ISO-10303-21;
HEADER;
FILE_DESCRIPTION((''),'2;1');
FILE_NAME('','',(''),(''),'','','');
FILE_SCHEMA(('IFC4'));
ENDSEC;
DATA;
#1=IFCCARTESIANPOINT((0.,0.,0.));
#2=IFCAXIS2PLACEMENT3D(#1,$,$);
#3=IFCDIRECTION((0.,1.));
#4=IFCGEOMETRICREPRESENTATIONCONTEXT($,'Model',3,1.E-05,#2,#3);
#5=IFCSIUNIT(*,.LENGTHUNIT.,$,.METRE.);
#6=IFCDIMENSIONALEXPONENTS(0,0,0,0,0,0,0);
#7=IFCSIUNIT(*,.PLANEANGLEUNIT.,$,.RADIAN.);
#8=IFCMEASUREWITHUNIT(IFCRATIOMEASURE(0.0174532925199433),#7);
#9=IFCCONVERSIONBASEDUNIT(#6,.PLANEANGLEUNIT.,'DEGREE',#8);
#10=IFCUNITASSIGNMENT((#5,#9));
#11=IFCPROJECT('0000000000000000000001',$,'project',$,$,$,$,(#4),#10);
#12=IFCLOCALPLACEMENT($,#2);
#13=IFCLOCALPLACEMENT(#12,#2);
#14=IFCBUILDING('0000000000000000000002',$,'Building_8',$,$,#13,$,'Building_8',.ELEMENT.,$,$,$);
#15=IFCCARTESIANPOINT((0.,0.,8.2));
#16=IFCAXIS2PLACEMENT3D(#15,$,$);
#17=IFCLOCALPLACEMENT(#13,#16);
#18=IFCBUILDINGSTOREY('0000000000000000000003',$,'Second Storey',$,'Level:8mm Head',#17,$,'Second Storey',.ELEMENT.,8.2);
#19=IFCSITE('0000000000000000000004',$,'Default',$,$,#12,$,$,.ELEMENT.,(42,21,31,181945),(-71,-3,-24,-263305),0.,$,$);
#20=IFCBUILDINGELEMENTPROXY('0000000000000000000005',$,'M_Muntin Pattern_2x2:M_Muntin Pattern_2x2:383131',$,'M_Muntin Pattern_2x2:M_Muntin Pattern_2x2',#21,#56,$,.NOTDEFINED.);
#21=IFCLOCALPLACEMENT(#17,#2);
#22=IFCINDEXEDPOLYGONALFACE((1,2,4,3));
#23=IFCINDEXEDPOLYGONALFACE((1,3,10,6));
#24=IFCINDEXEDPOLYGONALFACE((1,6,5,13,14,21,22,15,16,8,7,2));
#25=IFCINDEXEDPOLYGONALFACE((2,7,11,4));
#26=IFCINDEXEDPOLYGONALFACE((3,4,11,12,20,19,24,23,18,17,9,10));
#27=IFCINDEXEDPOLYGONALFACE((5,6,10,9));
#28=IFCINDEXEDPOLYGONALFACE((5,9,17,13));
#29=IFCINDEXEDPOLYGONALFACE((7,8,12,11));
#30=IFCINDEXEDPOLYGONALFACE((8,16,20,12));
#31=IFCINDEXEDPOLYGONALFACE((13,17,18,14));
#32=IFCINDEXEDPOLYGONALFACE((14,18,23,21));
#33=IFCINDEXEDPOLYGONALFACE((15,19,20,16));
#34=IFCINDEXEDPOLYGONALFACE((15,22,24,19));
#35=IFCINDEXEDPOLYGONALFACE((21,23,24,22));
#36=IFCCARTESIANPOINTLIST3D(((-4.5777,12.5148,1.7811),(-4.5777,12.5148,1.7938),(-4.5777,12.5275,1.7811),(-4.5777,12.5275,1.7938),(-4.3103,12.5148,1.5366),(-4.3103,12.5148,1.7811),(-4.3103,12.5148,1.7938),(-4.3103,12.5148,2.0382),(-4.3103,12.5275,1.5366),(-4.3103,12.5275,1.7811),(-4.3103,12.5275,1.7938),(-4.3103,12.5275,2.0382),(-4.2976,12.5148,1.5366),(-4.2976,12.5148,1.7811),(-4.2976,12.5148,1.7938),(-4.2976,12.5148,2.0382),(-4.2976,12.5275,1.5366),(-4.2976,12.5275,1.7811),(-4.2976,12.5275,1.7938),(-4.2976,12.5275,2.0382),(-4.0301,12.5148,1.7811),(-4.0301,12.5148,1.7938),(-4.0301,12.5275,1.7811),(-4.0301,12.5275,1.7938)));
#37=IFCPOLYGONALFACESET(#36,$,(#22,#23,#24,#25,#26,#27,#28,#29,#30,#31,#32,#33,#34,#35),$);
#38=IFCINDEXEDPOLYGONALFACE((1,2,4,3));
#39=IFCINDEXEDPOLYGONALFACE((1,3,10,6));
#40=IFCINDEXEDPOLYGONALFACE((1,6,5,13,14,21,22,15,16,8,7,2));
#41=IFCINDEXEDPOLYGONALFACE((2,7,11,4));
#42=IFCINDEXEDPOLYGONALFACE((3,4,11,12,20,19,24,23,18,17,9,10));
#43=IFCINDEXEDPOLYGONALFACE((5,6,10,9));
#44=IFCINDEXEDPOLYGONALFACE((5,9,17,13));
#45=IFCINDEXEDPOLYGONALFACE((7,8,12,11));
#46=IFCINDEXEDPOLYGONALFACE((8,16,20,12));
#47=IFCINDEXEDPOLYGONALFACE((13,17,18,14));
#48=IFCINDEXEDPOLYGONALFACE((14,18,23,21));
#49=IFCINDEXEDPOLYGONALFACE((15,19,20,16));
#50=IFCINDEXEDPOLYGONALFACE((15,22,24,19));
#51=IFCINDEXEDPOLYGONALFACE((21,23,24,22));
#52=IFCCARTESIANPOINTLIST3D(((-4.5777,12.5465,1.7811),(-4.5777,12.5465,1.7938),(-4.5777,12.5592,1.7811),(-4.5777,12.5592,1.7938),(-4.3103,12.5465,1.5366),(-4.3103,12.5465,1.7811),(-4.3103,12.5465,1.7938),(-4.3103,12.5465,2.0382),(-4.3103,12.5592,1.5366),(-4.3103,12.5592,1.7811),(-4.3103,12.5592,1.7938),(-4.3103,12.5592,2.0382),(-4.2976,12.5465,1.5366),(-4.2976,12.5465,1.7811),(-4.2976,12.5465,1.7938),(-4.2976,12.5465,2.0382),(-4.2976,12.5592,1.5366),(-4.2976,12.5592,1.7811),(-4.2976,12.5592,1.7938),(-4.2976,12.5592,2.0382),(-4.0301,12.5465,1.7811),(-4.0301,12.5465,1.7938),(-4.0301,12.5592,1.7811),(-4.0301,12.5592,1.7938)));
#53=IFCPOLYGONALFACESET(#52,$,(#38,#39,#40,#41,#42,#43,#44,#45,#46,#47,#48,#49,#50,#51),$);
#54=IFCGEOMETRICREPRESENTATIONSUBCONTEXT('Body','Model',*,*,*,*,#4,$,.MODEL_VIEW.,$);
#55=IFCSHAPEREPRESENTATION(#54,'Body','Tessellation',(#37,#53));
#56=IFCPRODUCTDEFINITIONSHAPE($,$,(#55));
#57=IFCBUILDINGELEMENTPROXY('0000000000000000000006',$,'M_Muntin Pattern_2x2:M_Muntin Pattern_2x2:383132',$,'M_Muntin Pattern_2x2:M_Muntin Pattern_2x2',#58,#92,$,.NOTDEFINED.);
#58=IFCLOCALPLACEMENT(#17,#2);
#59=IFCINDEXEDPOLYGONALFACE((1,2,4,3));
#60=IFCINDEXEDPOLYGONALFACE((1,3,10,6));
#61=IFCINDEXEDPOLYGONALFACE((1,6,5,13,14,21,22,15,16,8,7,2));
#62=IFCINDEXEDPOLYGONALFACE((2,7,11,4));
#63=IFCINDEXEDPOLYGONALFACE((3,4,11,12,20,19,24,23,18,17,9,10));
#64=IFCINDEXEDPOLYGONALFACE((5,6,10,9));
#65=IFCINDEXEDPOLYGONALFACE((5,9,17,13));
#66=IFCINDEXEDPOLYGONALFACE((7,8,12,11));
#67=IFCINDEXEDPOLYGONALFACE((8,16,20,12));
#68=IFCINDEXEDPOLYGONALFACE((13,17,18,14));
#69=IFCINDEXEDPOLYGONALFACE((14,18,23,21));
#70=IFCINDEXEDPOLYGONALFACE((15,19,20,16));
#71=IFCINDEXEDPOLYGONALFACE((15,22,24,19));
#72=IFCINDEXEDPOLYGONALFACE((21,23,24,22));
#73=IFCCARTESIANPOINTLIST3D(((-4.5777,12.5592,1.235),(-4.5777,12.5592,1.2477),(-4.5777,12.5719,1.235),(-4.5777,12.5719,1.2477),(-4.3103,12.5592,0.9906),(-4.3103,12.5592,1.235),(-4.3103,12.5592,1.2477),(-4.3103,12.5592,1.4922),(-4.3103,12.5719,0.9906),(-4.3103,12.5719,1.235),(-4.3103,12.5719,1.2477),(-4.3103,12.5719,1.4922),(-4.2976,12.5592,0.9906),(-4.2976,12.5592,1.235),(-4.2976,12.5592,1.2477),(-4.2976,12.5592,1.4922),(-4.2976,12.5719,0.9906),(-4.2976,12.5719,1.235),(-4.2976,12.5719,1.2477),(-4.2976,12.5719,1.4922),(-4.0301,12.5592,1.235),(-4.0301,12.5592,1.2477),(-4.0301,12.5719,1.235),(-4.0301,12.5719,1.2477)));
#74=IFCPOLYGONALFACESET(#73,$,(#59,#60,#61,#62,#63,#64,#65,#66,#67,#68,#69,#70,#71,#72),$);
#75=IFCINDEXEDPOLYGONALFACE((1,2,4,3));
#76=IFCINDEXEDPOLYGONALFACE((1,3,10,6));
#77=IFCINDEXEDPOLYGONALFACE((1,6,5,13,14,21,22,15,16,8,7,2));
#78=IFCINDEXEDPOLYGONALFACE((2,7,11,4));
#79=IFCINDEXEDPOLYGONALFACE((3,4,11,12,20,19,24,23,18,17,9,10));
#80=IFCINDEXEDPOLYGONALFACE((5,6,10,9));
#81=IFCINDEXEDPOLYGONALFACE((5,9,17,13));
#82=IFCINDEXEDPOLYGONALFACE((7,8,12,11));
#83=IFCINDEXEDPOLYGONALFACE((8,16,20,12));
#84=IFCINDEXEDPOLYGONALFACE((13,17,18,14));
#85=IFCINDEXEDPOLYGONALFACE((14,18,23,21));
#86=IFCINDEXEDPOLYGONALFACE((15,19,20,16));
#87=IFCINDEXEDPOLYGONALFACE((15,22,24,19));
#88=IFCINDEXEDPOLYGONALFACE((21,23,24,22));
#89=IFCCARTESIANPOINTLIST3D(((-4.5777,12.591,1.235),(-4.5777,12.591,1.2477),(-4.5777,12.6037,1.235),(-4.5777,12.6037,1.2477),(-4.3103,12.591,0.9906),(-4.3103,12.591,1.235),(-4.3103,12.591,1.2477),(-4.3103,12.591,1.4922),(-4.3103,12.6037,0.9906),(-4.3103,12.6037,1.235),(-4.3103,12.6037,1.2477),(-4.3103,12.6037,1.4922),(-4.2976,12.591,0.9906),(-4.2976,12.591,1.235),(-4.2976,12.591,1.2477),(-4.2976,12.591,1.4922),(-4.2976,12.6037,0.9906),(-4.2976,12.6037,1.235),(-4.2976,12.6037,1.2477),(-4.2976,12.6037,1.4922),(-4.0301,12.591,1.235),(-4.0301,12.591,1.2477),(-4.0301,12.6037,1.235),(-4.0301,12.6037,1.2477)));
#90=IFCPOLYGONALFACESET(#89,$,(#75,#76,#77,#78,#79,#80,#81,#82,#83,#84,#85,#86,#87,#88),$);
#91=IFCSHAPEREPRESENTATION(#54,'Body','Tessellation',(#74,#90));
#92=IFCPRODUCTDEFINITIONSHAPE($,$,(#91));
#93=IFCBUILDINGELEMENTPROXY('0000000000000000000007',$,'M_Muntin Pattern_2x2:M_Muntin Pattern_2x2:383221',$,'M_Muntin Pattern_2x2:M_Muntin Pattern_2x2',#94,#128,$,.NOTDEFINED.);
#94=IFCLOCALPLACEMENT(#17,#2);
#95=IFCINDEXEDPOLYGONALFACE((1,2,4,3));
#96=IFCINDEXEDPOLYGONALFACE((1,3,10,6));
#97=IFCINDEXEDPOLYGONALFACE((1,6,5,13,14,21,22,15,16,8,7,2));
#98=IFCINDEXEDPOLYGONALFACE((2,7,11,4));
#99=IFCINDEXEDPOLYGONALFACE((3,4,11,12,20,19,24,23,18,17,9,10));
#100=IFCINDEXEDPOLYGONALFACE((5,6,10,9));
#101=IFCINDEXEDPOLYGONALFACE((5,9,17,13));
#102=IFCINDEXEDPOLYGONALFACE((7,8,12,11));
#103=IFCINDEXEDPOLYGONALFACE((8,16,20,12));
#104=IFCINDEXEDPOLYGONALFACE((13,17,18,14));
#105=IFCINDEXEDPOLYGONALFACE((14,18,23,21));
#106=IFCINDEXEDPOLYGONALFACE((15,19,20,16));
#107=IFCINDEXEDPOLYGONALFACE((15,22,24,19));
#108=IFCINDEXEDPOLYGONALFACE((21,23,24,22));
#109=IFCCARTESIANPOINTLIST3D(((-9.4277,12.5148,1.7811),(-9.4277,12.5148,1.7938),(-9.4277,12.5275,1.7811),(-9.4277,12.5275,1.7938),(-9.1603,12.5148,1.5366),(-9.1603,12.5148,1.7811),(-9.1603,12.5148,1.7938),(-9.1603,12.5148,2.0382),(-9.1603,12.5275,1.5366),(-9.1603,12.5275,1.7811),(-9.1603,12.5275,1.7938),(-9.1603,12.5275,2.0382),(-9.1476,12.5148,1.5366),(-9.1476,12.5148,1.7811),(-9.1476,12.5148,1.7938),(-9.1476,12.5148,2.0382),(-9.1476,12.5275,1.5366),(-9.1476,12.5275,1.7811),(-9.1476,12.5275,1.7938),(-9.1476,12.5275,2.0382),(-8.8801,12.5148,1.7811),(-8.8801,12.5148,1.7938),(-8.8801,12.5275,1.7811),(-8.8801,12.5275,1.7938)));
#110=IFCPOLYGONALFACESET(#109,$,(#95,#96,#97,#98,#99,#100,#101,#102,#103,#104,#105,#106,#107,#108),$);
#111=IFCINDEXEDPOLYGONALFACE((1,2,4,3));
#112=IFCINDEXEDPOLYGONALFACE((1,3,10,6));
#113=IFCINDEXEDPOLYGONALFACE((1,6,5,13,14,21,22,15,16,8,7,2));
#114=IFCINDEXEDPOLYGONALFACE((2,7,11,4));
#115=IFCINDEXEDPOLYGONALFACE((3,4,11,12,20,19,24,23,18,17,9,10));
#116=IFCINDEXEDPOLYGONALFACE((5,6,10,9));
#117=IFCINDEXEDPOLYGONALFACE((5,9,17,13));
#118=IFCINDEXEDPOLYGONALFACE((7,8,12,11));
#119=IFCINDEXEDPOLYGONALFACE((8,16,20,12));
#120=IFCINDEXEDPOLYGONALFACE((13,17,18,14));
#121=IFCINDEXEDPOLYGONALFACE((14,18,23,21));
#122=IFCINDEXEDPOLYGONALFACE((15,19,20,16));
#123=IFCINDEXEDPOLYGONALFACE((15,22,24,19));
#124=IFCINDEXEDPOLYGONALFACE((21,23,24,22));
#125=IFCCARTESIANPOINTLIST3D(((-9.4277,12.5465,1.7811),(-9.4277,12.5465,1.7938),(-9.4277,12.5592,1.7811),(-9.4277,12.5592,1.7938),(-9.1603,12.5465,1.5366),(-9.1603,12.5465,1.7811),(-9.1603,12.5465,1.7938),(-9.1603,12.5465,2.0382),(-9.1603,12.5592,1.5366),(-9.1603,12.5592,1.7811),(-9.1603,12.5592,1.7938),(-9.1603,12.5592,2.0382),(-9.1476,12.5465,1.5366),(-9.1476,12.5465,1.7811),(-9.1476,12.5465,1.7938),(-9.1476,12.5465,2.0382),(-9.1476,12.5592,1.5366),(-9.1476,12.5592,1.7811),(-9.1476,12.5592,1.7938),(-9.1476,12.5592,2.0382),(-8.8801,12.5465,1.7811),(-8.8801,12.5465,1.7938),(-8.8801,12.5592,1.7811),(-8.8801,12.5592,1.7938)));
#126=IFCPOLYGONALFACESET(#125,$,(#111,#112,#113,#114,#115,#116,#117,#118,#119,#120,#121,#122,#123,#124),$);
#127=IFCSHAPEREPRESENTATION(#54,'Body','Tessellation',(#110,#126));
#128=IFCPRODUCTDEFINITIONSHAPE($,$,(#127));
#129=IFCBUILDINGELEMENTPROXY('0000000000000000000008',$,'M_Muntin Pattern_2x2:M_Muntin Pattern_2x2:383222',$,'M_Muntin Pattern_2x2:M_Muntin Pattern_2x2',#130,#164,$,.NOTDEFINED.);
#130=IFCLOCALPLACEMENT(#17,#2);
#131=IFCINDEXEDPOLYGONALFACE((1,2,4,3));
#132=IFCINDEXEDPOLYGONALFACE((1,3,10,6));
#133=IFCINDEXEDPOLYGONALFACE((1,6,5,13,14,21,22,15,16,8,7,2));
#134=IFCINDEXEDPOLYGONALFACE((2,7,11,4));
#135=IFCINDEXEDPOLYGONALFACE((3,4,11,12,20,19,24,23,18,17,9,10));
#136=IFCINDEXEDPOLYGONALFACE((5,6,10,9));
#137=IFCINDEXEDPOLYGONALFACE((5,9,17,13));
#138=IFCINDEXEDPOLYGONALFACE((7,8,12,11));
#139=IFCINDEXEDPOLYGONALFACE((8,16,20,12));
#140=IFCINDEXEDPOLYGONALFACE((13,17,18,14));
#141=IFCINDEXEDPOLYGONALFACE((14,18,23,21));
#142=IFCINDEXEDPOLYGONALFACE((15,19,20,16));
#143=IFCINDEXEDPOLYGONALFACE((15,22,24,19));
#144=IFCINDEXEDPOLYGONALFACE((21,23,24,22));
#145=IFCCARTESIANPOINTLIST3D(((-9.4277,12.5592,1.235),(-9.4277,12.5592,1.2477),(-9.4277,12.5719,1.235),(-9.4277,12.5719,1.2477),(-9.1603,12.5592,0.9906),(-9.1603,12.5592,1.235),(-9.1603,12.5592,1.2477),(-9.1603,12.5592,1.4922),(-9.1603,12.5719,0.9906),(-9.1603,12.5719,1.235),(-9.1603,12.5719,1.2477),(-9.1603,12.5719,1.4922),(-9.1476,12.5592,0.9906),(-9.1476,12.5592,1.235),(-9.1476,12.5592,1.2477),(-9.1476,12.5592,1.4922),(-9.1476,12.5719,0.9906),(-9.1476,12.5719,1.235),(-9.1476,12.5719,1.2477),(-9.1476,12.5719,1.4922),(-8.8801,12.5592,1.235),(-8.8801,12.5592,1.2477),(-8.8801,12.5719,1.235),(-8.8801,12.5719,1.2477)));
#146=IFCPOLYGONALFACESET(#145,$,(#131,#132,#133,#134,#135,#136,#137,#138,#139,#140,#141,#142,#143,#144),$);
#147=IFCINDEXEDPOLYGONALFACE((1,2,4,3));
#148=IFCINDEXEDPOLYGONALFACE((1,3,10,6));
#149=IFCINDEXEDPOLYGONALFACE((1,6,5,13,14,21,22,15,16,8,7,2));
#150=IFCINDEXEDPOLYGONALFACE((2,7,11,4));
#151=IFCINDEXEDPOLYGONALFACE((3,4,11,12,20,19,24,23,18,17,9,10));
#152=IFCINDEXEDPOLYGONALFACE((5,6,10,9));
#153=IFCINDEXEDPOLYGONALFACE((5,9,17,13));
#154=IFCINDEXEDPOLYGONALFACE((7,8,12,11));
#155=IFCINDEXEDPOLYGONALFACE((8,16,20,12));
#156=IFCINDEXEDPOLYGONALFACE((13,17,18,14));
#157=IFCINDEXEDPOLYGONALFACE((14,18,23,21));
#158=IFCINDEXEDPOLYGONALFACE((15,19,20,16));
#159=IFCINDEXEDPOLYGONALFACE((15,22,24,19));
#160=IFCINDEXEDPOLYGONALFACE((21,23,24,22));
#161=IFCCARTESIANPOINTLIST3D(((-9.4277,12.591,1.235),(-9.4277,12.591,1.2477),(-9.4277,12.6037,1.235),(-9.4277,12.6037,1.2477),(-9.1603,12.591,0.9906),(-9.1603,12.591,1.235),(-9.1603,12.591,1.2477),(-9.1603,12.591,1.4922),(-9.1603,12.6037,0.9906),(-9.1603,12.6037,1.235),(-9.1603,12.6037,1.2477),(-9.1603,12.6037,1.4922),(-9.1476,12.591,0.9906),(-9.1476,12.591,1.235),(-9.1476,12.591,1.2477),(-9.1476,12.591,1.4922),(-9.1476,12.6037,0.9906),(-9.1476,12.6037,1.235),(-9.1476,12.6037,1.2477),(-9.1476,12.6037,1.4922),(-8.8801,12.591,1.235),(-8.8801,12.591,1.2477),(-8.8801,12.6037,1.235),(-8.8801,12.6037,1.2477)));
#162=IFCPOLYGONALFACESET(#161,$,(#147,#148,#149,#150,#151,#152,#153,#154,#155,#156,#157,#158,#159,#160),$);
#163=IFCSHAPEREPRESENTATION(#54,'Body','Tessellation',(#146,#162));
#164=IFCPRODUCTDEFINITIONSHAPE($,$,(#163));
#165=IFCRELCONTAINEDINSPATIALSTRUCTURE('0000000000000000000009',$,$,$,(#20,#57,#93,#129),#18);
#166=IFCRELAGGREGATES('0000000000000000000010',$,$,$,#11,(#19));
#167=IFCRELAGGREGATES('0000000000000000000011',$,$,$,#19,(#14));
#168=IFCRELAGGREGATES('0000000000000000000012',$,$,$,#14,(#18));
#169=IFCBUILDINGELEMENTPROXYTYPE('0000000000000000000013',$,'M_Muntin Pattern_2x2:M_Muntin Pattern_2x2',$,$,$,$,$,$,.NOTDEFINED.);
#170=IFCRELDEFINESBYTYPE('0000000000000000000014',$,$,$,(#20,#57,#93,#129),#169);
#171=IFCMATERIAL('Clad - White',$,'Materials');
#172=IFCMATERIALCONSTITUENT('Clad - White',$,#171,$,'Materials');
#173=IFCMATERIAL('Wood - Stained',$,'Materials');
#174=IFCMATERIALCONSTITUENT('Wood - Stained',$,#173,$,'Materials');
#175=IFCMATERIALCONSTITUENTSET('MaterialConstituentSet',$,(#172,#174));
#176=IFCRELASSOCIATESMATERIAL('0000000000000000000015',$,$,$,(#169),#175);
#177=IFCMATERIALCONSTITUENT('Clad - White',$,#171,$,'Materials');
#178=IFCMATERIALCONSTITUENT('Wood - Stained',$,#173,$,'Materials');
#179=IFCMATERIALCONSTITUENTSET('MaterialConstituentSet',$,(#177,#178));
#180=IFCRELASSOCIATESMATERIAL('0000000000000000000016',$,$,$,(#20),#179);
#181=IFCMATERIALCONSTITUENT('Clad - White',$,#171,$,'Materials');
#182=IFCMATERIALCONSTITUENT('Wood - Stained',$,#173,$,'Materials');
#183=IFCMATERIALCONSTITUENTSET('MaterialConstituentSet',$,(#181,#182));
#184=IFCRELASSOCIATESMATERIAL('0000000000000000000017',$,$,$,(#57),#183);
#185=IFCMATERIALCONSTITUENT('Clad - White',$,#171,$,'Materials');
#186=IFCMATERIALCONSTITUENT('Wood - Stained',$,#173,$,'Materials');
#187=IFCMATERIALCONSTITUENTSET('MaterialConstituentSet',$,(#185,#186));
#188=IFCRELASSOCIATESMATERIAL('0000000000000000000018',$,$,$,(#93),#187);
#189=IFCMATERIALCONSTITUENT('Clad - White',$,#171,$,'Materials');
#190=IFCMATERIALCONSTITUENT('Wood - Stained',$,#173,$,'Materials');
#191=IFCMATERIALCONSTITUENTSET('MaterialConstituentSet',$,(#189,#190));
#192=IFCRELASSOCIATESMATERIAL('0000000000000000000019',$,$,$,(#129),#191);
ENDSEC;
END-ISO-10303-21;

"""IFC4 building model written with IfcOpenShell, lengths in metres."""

from ifc_helpers import new_model, entity, si_unit, converted_unit, direction, frame, origin, place, context, subcontext, project, spatial, indexed_curve, outline, extrude, source, transform, mapped, material, constituent, constituent_set, type_object, type_shapes, element, save


model = new_model("IFC4")

# Units and contexts
model_context = context("Model", 3, precision=1e-05, world=origin(), true_north=direction((0.0, 1.0)))
body_context = subcontext(model_context, "Body", "Model", "MODEL_VIEW")
ifc_project = project(units=[si_unit("LENGTHUNIT", "METRE"), converted_unit("PLANEANGLEUNIT", "DEGREE", entity("IfcRatioMeasure", 0.0174532925199433), si_unit("PLANEANGLEUNIT", "RADIAN"), dimensions=[0, 0, 0, 0, 0, 0, 0])], contexts=[model_context])

# Site, building, storey
site_placement = place(None, origin())
site = spatial("IfcSite", under=ifc_project, at=site_placement, Name="Default", CompositionType="ELEMENT", RefLatitude=(42, 21, 31, 181945), RefLongitude=(-71, -3, -24, -263305), RefElevation=0.0)
building_placement = place(site_placement, origin())
building = spatial("IfcBuilding", under=site, at=building_placement, Name="Building_8", LongName="Building_8", CompositionType="ELEMENT")
storey_placement = place(building_placement, frame((0.0, 0.0, 8.2)))
storey = spatial("IfcBuildingStorey", under=building, at=storey_placement, Name="Second Storey", ObjectType="Level:8mm Head", LongName="Second Storey", CompositionType="ELEMENT", Elevation=8.2)

# Shared definitions
ifc_material_1 = material(Name="Clad - White", Category="Materials")
ifc_material_2 = material(Name="Wood - Stained", Category="Materials")

# Building element proxies
ifc_constituent_1 = constituent(ifc_material_1, Name="Clad - White", Category="Materials")
ifc_constituent_2 = constituent(ifc_material_2, Name="Wood - Stained", Category="Materials")
ifc_constituent_set_1 = constituent_set(constituents=[ifc_constituent_1, ifc_constituent_2], Name="MaterialConstituentSet")
ifc_constituent_3 = constituent(ifc_material_1, Name="Clad - White", Category="Materials")
ifc_constituent_4 = constituent(ifc_material_2, Name="Wood - Stained", Category="Materials")
ifc_constituent_set_2 = constituent_set(constituents=[ifc_constituent_3, ifc_constituent_4], Name="MaterialConstituentSet")
building_element_proxy_type_1 = type_object("IfcBuildingElementProxyType", Name="M_Muntin Pattern_2x2:M_Muntin Pattern_2x2", PredefinedType="NOTDEFINED", material=ifc_constituent_set_2)
shared_shape_1 = source(origin(), body_context, "Body", "SweptSolid", [
    extrude(outline(indexed_curve([(0.0064, -0.0064), (0.2508, -0.0064), (0.2508, 0.0063), (0.0064, 0.0063), (0.0064, 0.2738), (-0.0063, 0.2738), (-0.0063, 0.0063), (-0.2508, 0.0063), (-0.2508, -0.0064), (-0.0063, -0.0064), (-0.0063, -0.2738), (0.0064, -0.2738), (0.0064, -0.0064)], self_intersect=False)), frame((0.0, 0.0095, 0.2508), z_axis=(0.0, 1.0, 0.0), x_axis=(0.0, 0.0, 1.0)), (0.0, 0.0, 1.0), 0.0127),
    extrude(outline(indexed_curve([(0.0064, -0.0064), (0.2508, -0.0064), (0.2508, 0.0063), (0.0064, 0.0063), (0.0064, 0.2738), (-0.0063, 0.2738), (-0.0063, 0.0063), (-0.2508, 0.0063), (-0.2508, -0.0064), (-0.0063, -0.0064), (-0.0063, -0.2738), (0.0064, -0.2738), (0.0064, -0.0064)], self_intersect=False)), frame((0.0, -0.0222, 0.2508), z_axis=(0.0, 1.0, 0.0), x_axis=(0.0, 0.0, 1.0)), (0.0, 0.0, 1.0), 0.0127),
])
type_shapes(building_element_proxy_type_1, [shared_shape_1])
proxy_1_placement = place(storey_placement, frame((-4.3039, 12.537, 1.5366), z_axis=(0.0, 0.0, 1.0), x_axis=(-1.0, 0.0, 0.0)))
element("IfcBuildingElementProxy", 1, at=proxy_1_placement, inside=storey, type_object=building_element_proxy_type_1, material=ifc_constituent_set_1, Name="M_Muntin Pattern_2x2:M_Muntin Pattern_2x2:383131", ObjectType="M_Muntin Pattern_2x2:M_Muntin Pattern_2x2", PredefinedType="NOTDEFINED", context=body_context, shape_type="MappedRepresentation", body=[
    mapped(shared_shape_1, transform((0.0, 0.0, 0.0), scale=1.0)),
])
ifc_constituent_5 = constituent(ifc_material_1, Name="Clad - White", Category="Materials")
ifc_constituent_6 = constituent(ifc_material_2, Name="Wood - Stained", Category="Materials")
ifc_constituent_set_3 = constituent_set(constituents=[ifc_constituent_5, ifc_constituent_6], Name="MaterialConstituentSet")
proxy_2_placement = place(storey_placement, frame((-4.3039, 12.5814, 0.9906), z_axis=(0.0, 0.0, 1.0), x_axis=(-1.0, 0.0, 0.0)))
element("IfcBuildingElementProxy", 2, at=proxy_2_placement, inside=storey, type_object=building_element_proxy_type_1, material=ifc_constituent_set_3, Name="M_Muntin Pattern_2x2:M_Muntin Pattern_2x2:383132", ObjectType="M_Muntin Pattern_2x2:M_Muntin Pattern_2x2", PredefinedType="NOTDEFINED", context=body_context, shape_type="MappedRepresentation", body=[
    mapped(shared_shape_1, transform((0.0, 0.0, 0.0), scale=1.0)),
])
ifc_constituent_7 = constituent(ifc_material_1, Name="Clad - White", Category="Materials")
ifc_constituent_8 = constituent(ifc_material_2, Name="Wood - Stained", Category="Materials")
ifc_constituent_set_4 = constituent_set(constituents=[ifc_constituent_7, ifc_constituent_8], Name="MaterialConstituentSet")
proxy_3_placement = place(storey_placement, frame((-9.1539, 12.537, 1.5366), z_axis=(0.0, 0.0, 1.0), x_axis=(-1.0, 0.0, 0.0)))
element("IfcBuildingElementProxy", 3, at=proxy_3_placement, inside=storey, type_object=building_element_proxy_type_1, material=ifc_constituent_set_4, Name="M_Muntin Pattern_2x2:M_Muntin Pattern_2x2:383221", ObjectType="M_Muntin Pattern_2x2:M_Muntin Pattern_2x2", PredefinedType="NOTDEFINED", context=body_context, shape_type="MappedRepresentation", body=[
    mapped(shared_shape_1, transform((0.0, 0.0, 0.0), scale=1.0)),
])
ifc_constituent_9 = constituent(ifc_material_1, Name="Clad - White", Category="Materials")
ifc_constituent_10 = constituent(ifc_material_2, Name="Wood - Stained", Category="Materials")
ifc_constituent_set_5 = constituent_set(constituents=[ifc_constituent_9, ifc_constituent_10], Name="MaterialConstituentSet")
proxy_4_placement = place(storey_placement, frame((-9.1539, 12.5814, 0.9906), z_axis=(0.0, 0.0, 1.0), x_axis=(-1.0, 0.0, 0.0)))
element("IfcBuildingElementProxy", 4, at=proxy_4_placement, inside=storey, type_object=building_element_proxy_type_1, material=ifc_constituent_set_5, Name="M_Muntin Pattern_2x2:M_Muntin Pattern_2x2:383222", ObjectType="M_Muntin Pattern_2x2:M_Muntin Pattern_2x2", PredefinedType="NOTDEFINED", context=body_context, shape_type="MappedRepresentation", body=[
    mapped(shared_shape_1, transform((0.0, 0.0, 0.0), scale=1.0)),
])

save(model, "model.ifc")
